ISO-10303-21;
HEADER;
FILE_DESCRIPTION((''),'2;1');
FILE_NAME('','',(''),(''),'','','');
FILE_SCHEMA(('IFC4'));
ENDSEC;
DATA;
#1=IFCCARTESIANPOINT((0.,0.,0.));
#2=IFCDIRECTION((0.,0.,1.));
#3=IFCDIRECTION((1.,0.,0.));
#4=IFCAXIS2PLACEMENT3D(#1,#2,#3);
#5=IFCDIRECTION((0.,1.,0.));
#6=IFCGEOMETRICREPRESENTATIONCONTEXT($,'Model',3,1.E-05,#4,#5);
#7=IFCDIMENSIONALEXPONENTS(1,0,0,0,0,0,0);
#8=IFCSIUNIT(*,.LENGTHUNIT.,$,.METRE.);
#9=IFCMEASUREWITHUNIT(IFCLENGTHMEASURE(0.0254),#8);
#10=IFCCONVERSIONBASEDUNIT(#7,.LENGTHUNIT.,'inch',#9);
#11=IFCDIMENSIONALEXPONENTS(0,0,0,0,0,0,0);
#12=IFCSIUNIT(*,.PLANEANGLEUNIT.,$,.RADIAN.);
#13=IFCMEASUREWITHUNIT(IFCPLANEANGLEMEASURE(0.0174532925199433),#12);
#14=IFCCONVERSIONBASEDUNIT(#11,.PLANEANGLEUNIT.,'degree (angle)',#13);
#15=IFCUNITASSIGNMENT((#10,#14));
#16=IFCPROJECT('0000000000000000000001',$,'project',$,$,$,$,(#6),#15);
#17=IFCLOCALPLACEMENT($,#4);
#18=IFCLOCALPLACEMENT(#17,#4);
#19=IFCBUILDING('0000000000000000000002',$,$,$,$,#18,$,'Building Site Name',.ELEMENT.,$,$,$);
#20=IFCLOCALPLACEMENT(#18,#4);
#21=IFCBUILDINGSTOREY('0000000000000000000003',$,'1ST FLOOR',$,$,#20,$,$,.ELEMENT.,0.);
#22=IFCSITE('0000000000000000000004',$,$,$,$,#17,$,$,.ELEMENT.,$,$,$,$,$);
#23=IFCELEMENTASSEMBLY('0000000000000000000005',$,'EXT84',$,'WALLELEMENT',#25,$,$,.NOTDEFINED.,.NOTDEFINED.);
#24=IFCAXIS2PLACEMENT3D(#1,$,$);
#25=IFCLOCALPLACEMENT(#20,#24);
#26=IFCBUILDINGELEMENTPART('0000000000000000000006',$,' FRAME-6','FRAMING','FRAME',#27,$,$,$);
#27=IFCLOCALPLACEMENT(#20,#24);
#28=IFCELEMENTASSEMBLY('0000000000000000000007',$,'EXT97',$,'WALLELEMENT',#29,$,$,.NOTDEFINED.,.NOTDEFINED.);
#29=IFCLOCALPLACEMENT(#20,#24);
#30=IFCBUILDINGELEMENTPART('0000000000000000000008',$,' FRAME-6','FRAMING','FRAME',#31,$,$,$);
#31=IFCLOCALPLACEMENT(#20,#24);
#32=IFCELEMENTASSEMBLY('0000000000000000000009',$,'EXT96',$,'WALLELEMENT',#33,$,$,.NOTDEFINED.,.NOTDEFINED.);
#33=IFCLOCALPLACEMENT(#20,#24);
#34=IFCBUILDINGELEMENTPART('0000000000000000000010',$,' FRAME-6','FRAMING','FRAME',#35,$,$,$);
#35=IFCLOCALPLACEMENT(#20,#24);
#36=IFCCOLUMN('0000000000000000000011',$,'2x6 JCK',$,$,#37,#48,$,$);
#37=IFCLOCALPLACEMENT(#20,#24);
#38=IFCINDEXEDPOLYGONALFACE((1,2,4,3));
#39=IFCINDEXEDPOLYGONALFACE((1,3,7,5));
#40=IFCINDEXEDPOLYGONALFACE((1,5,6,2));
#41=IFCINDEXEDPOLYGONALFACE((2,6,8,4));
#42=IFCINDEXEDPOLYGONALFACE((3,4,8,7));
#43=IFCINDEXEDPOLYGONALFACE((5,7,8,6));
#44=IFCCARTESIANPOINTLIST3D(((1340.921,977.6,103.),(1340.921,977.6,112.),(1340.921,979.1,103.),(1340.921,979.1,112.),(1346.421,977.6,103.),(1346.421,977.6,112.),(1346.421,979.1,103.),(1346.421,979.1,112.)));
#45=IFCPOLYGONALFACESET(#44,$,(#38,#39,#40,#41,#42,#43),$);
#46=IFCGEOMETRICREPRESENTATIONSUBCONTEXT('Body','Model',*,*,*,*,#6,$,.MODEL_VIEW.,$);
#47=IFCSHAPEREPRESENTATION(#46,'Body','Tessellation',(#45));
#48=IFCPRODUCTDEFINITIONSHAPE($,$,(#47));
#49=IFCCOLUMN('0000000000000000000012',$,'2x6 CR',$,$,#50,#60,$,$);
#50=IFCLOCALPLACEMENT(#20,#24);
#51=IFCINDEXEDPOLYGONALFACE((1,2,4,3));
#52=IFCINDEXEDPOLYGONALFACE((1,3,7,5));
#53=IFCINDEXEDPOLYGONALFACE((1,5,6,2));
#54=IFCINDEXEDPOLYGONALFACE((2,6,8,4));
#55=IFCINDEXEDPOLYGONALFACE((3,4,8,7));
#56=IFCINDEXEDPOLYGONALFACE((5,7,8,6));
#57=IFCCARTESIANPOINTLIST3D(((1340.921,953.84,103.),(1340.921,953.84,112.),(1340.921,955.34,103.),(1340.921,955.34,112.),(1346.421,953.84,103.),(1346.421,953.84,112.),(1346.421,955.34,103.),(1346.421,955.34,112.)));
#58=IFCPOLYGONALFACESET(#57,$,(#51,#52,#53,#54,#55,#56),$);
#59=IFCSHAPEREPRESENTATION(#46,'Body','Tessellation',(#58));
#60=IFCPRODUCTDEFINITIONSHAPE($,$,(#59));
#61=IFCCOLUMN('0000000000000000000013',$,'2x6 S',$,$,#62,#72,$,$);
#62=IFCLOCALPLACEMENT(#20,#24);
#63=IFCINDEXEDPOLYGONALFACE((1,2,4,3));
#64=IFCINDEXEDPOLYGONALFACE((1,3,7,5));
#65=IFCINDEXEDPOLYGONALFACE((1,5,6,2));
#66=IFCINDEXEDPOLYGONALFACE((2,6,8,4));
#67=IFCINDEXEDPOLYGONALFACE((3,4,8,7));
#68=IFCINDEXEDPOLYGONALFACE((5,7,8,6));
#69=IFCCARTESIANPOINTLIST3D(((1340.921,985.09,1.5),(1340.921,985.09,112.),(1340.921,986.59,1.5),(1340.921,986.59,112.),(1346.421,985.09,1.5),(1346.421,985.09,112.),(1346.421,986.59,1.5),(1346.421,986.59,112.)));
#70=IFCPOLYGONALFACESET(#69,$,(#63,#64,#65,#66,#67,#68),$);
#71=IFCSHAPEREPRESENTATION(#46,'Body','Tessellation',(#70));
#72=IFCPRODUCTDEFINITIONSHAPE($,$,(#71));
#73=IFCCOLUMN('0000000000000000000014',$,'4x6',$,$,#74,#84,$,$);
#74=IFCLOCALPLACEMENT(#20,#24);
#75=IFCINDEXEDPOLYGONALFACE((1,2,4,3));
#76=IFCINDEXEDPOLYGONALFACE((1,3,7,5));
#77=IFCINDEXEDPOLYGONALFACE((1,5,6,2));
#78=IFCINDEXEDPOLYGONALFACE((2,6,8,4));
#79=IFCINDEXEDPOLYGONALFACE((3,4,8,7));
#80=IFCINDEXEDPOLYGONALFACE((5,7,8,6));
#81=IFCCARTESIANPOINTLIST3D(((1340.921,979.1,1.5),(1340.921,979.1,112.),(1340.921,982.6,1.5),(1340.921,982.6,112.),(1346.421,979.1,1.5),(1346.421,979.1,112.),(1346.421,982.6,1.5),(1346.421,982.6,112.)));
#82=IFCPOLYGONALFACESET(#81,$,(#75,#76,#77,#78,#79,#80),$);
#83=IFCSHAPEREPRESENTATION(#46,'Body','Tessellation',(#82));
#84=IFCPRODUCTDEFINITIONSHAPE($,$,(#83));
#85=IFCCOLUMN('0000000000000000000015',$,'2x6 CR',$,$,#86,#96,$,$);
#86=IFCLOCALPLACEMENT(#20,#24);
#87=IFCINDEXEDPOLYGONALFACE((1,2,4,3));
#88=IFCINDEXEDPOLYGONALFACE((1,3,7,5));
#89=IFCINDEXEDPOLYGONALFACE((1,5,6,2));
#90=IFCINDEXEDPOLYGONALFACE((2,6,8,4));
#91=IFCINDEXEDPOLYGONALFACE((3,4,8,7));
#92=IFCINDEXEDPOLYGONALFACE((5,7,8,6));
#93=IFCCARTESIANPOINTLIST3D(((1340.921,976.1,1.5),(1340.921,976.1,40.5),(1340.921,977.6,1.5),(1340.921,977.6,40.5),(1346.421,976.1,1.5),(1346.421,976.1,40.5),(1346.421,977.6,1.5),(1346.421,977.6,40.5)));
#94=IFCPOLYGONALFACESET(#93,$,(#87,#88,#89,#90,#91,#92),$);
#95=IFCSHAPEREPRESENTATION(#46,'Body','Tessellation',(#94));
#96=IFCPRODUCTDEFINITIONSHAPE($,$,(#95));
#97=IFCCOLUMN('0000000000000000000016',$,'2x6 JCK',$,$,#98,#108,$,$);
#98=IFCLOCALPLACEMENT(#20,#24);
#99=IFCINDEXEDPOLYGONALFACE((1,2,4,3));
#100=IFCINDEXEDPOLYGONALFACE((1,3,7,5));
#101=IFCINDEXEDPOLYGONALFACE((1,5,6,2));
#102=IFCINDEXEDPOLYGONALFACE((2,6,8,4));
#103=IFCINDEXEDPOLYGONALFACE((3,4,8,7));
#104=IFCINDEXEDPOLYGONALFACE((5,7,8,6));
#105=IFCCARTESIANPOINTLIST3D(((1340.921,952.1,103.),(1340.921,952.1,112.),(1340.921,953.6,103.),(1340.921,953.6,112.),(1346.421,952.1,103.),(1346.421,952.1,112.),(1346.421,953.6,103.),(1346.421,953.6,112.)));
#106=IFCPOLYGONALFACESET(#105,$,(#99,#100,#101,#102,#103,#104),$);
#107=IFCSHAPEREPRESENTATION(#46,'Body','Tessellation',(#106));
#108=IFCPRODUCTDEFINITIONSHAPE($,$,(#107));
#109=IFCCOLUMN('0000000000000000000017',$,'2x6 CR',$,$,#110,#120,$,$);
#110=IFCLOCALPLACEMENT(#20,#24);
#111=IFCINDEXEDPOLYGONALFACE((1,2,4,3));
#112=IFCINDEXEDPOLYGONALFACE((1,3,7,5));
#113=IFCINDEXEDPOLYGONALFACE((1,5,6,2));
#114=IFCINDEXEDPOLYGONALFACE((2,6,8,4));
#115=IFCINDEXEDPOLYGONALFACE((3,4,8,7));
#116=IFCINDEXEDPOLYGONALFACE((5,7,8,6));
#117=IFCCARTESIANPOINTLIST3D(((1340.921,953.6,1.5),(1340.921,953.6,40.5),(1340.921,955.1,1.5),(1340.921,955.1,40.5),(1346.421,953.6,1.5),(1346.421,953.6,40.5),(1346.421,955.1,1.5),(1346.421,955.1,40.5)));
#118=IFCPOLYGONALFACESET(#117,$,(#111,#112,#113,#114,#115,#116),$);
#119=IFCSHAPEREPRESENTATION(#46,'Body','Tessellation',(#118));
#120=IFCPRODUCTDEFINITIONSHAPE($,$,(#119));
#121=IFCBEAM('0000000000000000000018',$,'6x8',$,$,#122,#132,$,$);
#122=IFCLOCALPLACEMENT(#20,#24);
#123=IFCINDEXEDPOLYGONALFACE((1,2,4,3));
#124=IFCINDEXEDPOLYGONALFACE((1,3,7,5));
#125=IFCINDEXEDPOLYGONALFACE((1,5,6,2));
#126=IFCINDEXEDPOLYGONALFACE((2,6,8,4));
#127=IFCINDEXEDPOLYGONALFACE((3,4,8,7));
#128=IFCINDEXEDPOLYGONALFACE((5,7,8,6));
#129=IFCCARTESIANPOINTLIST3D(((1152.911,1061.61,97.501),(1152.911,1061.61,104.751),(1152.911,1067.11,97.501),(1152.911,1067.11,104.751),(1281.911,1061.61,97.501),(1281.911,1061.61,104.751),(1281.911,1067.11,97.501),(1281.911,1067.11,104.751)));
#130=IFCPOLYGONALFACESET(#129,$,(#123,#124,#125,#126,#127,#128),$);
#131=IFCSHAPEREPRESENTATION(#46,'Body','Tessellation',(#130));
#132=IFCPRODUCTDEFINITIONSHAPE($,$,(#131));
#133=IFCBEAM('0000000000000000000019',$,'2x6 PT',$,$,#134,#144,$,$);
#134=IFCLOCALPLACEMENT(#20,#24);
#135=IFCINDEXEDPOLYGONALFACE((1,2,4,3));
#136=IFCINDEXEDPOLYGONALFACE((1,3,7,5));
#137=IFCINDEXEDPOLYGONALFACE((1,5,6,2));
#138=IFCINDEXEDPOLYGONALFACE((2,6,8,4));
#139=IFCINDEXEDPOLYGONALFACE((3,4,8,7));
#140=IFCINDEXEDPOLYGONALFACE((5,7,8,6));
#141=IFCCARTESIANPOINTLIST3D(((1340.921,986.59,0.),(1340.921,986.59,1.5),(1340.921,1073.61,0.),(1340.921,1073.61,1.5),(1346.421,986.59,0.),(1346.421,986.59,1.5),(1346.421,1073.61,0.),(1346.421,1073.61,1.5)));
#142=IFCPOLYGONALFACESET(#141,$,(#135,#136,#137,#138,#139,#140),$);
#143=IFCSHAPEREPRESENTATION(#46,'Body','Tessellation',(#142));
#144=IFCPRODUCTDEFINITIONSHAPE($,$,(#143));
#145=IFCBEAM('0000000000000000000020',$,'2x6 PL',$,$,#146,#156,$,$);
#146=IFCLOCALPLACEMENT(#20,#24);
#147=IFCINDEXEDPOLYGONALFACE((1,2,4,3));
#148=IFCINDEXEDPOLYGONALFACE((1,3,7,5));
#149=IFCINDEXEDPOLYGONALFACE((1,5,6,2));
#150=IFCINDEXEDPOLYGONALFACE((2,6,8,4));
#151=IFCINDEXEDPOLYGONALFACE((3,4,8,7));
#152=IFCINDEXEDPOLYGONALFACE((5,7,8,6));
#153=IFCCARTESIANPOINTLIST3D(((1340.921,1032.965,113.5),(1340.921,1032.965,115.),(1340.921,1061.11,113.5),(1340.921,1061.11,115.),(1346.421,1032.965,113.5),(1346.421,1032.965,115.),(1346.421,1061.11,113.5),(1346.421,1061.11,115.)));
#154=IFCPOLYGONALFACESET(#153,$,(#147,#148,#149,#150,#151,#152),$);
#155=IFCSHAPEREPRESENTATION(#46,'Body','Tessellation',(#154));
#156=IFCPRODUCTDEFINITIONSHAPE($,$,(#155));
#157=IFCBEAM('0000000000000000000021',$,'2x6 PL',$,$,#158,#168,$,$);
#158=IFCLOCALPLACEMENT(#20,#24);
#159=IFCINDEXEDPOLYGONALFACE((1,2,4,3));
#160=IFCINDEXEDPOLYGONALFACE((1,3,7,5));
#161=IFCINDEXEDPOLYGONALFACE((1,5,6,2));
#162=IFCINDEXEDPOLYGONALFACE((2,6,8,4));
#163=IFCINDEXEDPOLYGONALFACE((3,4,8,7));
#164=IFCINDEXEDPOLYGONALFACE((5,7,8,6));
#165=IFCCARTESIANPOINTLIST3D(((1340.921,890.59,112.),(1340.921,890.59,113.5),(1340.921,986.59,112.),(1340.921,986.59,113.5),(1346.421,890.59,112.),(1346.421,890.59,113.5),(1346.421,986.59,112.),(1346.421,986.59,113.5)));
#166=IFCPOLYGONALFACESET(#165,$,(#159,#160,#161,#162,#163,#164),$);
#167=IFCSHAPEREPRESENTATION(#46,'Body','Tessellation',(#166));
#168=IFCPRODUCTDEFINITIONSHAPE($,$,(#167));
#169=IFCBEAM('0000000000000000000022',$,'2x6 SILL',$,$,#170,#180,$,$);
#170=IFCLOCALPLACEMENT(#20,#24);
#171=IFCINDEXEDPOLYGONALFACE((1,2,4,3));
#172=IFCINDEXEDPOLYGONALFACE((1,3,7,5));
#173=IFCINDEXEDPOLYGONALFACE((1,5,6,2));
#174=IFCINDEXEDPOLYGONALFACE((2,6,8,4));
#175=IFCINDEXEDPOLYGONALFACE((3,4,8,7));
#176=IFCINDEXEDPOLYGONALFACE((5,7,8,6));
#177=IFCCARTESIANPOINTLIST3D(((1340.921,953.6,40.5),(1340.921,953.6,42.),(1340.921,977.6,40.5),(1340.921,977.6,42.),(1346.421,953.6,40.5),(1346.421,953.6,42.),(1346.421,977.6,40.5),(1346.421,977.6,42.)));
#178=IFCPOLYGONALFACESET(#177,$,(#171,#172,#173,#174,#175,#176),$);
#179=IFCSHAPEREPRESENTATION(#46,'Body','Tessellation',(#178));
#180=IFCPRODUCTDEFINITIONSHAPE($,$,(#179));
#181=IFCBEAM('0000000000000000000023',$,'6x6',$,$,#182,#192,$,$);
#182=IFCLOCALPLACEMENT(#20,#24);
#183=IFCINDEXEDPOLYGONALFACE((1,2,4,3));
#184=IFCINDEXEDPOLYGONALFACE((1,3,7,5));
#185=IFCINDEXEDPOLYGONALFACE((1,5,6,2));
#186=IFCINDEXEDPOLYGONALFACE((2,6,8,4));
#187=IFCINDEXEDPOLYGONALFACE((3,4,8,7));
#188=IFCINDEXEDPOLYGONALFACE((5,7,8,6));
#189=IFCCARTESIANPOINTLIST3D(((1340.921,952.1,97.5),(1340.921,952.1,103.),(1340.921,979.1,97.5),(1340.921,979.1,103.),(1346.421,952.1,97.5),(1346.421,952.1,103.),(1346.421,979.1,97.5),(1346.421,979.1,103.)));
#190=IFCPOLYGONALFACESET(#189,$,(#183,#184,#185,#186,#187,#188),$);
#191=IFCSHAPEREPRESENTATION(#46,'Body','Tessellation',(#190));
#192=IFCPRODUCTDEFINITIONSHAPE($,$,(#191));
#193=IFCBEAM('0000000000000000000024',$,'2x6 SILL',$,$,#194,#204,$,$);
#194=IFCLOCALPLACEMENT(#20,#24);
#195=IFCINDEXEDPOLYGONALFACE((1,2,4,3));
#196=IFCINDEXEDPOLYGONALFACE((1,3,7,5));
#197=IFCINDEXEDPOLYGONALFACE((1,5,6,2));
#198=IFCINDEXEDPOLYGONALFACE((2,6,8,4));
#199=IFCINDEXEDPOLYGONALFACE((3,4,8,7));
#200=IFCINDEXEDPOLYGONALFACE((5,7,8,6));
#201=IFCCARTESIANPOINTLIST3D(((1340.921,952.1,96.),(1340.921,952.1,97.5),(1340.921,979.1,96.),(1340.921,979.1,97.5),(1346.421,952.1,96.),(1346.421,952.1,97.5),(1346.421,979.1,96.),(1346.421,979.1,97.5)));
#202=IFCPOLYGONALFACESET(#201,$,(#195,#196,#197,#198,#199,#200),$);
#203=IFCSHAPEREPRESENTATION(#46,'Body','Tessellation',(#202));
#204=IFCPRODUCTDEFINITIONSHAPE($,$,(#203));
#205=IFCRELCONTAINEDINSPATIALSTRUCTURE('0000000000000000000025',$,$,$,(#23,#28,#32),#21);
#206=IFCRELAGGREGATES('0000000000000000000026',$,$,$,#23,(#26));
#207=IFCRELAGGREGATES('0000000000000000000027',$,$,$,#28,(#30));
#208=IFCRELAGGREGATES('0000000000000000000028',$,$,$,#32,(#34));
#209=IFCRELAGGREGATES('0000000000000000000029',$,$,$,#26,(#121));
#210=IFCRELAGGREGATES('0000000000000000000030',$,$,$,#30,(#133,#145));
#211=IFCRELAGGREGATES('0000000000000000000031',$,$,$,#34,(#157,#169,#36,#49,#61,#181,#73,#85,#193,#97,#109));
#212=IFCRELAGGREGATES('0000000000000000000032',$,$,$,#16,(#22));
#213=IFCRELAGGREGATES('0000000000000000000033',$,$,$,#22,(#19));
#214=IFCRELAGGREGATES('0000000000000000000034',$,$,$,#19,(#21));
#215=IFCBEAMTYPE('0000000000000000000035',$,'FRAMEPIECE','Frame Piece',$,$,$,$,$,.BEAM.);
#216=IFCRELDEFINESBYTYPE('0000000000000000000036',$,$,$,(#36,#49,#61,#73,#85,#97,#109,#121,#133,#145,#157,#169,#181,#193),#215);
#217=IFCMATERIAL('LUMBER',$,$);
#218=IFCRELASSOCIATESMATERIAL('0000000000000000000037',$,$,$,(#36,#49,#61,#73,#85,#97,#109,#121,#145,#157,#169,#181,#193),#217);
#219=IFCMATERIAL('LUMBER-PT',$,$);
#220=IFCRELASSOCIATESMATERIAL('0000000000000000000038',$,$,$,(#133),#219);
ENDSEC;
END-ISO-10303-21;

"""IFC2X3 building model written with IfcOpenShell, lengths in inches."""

from ifc_helpers import new_model, entity, si_unit, converted_unit, direction, frame, frame_2d, origin_with_axes, place, context, subcontext, project, spatial, polyline, segment, composite_curve, rectangle, outline, extrude, material, type_object, element, aggregate, save


model = new_model("IFC2X3")

# Units and contexts
model_context = context("Model", 3, precision=1e-05, world=origin_with_axes(), true_north=direction((0.0, 1.0, 0.0)))
body_context = subcontext(model_context, "Body", "Model", "MODEL_VIEW")
ifc_project = project(units=[converted_unit("LENGTHUNIT", "inch", entity("IfcLengthMeasure", 0.0254), si_unit("LENGTHUNIT", "METRE"), dimensions=[1, 0, 0, 0, 0, 0, 0]), converted_unit("PLANEANGLEUNIT", "degree (angle)", entity("IfcPlaneAngleMeasure", 0.0174532925199433), si_unit("PLANEANGLEUNIT", "RADIAN"), dimensions=[0, 0, 0, 0, 0, 0, 0])], contexts=[model_context])

# Site, building, storey
site_placement = place(None, origin_with_axes())
site = spatial("IfcSite", under=ifc_project, at=site_placement, CompositionType="ELEMENT")
building_placement = place(site_placement, origin_with_axes())
building = spatial("IfcBuilding", under=site, at=building_placement, LongName="Building Site Name", CompositionType="ELEMENT")
storey_placement = place(building_placement, origin_with_axes())
storey = spatial("IfcBuildingStorey", under=building, at=storey_placement, Name="1ST FLOOR", CompositionType="ELEMENT", Elevation=0.0)

# Element assemblies, building element parts, columns
assembly_1_placement = place(storey_placement, origin_with_axes())
assembly_1 = element("IfcElementAssembly", 1, at=assembly_1_placement, inside=storey, Name="EXT84", ObjectType="WALLELEMENT", AssemblyPlace="NOTDEFINED", PredefinedType="NOTDEFINED")
building_element_part_1 = element("IfcBuildingElementPart", 2, Name=" FRAME-6", Description="FRAMING", ObjectType="FRAME")
aggregate(assembly_1, [building_element_part_1])
ifc_material_1 = material(Name="LUMBER")
beam_type = type_object("IfcBeamType", Name="FRAMEPIECE", Description="Frame Piece", PredefinedType="BEAM")
assembly_2_placement = place(storey_placement, origin_with_axes())
assembly_2 = element("IfcElementAssembly", 3, at=assembly_2_placement, inside=storey, Name="EXT97", ObjectType="WALLELEMENT", AssemblyPlace="NOTDEFINED", PredefinedType="NOTDEFINED")
building_element_part_2 = element("IfcBuildingElementPart", 4, Name=" FRAME-6", Description="FRAMING", ObjectType="FRAME")
aggregate(assembly_2, [building_element_part_2])
assembly_3_placement = place(storey_placement, origin_with_axes())
assembly_3 = element("IfcElementAssembly", 5, at=assembly_3_placement, inside=storey, Name="EXT96", ObjectType="WALLELEMENT", AssemblyPlace="NOTDEFINED", PredefinedType="NOTDEFINED")
building_element_part_3 = element("IfcBuildingElementPart", 6, Name=" FRAME-6", Description="FRAMING", ObjectType="FRAME")
aggregate(assembly_3, [building_element_part_3])
column_1_placement = place(assembly_3_placement, frame((1343.671, 978.35, 103.0), z_axis=(0.0, 0.0, 1.0), x_axis=(0.0, -1.0, 0.0)))
column_1 = element("IfcColumn", 7, at=column_1_placement, type_object=beam_type, material=ifc_material_1, Name="2x6 JCK", context=body_context, shape_type="SweptSolid", body=[
    extrude(rectangle(XDim=1.5, YDim=5.5, at=frame_2d((0.0, 0.0), x_axis=(-1.0, 0.0))), origin_with_axes(), (0.0, 0.0, 1.0), 9.0),
])
column_2_placement = place(assembly_3_placement, frame((1343.671, 954.59, 112.0), z_axis=(0.0, 0.0, -1.0), x_axis=(0.0, 1.0, 0.0)))
column_2 = element("IfcColumn", 8, at=column_2_placement, type_object=beam_type, material=ifc_material_1, Name="2x6 CR", context=body_context, shape_type="SweptSolid", body=[
    extrude(rectangle(XDim=1.5, YDim=5.5, at=frame_2d((0.0, 0.0), x_axis=(-1.0, 0.0))), origin_with_axes(), (0.0, 0.0, 1.0), 9.0),
])
column_3_placement = place(assembly_3_placement, frame((1343.671, 985.84, 1.5), z_axis=(0.0, 0.0, 1.0), x_axis=(0.0, -1.0, 0.0)))
column_3 = element("IfcColumn", 9, at=column_3_placement, type_object=beam_type, material=ifc_material_1, Name="2x6 S", context=body_context, shape_type="SweptSolid", body=[
    extrude(rectangle(XDim=1.5, YDim=5.5, at=frame_2d((0.0, 0.0), x_axis=(-1.0, 0.0))), frame((0.0, 0.0, 0.0), z_axis=(0.0, 0.0, 1.0), x_axis=(1.0, 0.0, 0.0)), (0.0, 0.0, 1.0), 110.5),
])
column_4_placement = place(assembly_3_placement, frame((1343.671, 980.85, 1.5), z_axis=(0.0, 0.0, 1.0), x_axis=(0.0, -1.0, 0.0)))
column_4 = element("IfcColumn", 10, at=column_4_placement, type_object=beam_type, material=ifc_material_1, Name="4x6", context=body_context, shape_type="SweptSolid", body=[
    extrude(outline(composite_curve([segment(polyline([(-1.75, -2.75), (-1.75, 2.75), (1.75, 2.75), (1.75, -2.75), (-1.75, -2.75)]), True, "CONTINUOUS")], self_intersect=False)), origin_with_axes(), (0.0, 0.0, 1.0), 110.5),
])
column_5_placement = place(assembly_3_placement, frame((1343.671, 976.85, 1.5), z_axis=(0.0, 0.0, 1.0), x_axis=(0.0, -1.0, 0.0)))
column_5 = element("IfcColumn", 11, at=column_5_placement, type_object=beam_type, material=ifc_material_1, Name="2x6 CR", context=body_context, shape_type="SweptSolid", body=[
    extrude(rectangle(XDim=1.5, YDim=5.5, at=frame_2d((0.0, 0.0), x_axis=(-1.0, 0.0))), frame((0.0, 0.0, 0.0), z_axis=(0.0, 0.0, 1.0), x_axis=(1.0, 0.0, 0.0)), (0.0, 0.0, 1.0), 39.0),
])
column_6_placement = place(assembly_3_placement, frame((1343.671, 952.85, 112.0), z_axis=(0.0, 0.0, -1.0), x_axis=(0.0, 1.0, 0.0)))
column_6 = element("IfcColumn", 12, at=column_6_placement, type_object=beam_type, material=ifc_material_1, Name="2x6 JCK", context=body_context, shape_type="SweptSolid", body=[
    extrude(rectangle(XDim=1.5, YDim=5.5, at=frame_2d((0.0, 0.0), x_axis=(-1.0, 0.0))), origin_with_axes(), (0.0, 0.0, 1.0), 9.0),
])
column_7_placement = place(assembly_3_placement, frame((1343.671, 954.35, 40.5), z_axis=(0.0, 0.0, -1.0), x_axis=(0.0, 1.0, 0.0)))
column_7 = element("IfcColumn", 13, at=column_7_placement, type_object=beam_type, material=ifc_material_1, Name="2x6 CR", context=body_context, shape_type="SweptSolid", body=[
    extrude(rectangle(XDim=1.5, YDim=5.5, at=frame_2d((0.0, 0.0), x_axis=(-1.0, 0.0))), origin_with_axes(), (0.0, 0.0, 1.0), 39.0),
])

# Beams
beam_1_placement = place(assembly_1_placement, frame((1281.911, 1064.36, 101.126), z_axis=(-1.0, 0.0, 0.0), x_axis=(0.0, -1.0, 0.0)))
beam_1 = element("IfcBeam", 14, at=beam_1_placement, type_object=beam_type, material=ifc_material_1, Name="6x8", context=body_context, shape_type="SweptSolid", body=[
    extrude(rectangle(XDim=5.5, YDim=7.25, at=frame_2d((0.0, 0.0), x_axis=(-1.0, 0.0))), frame((0.0, 0.0, 0.0), z_axis=(0.0, 0.0, 1.0), x_axis=(1.0, 0.0, 0.0)), (0.0, 0.0, 1.0), 129.0),
])
aggregate(building_element_part_1, [beam_1])
ifc_material_2 = material(Name="LUMBER-PT")
beam_2_placement = place(assembly_2_placement, frame((1343.671, 986.59, 0.75), z_axis=(0.0, 1.0, 0.0), x_axis=(0.0, 0.0, 1.0)))
beam_2 = element("IfcBeam", 15, at=beam_2_placement, type_object=beam_type, material=ifc_material_2, Name="2x6 PT", context=body_context, shape_type="SweptSolid", body=[
    extrude(rectangle(XDim=1.5, YDim=5.5, at=frame_2d((0.0, 0.0), x_axis=(-1.0, 0.0))), origin_with_axes(), (0.0, 0.0, 1.0), 87.02),
])
beam_3_placement = place(assembly_2_placement, frame((1343.671, 1061.11, 114.25), z_axis=(0.0, -1.0, 0.0), x_axis=(0.0, 0.0, -1.0)))
beam_3 = element("IfcBeam", 16, at=beam_3_placement, type_object=beam_type, material=ifc_material_1, Name="2x6 PL", context=body_context, shape_type="SweptSolid", body=[
    extrude(rectangle(XDim=1.5, YDim=5.5, at=frame_2d((0.0, 0.0), x_axis=(-1.0, 0.0))), origin_with_axes(), (0.0, 0.0, 1.0), 28.145),
])
aggregate(building_element_part_2, [beam_2, beam_3])
beam_4_placement = place(assembly_3_placement, frame((1343.671, 986.59, 112.75), z_axis=(0.0, -1.0, 0.0), x_axis=(0.0, 0.0, -1.0)))
beam_4 = element("IfcBeam", 17, at=beam_4_placement, type_object=beam_type, material=ifc_material_1, Name="2x6 PL", context=body_context, shape_type="SweptSolid", body=[
    extrude(rectangle(XDim=1.5, YDim=5.5, at=frame_2d((0.0, 0.0), x_axis=(-1.0, 0.0))), origin_with_axes(), (0.0, 0.0, 1.0), 96.0),
])
beam_5_placement = place(assembly_3_placement, frame((1343.671, 977.6, 41.25), z_axis=(0.0, -1.0, 0.0), x_axis=(0.0, 0.0, -1.0)))
beam_5 = element("IfcBeam", 18, at=beam_5_placement, type_object=beam_type, material=ifc_material_1, Name="2x6 SILL", context=body_context, shape_type="SweptSolid", body=[
    extrude(rectangle(XDim=1.5, YDim=5.5, at=frame_2d((0.0, 0.0), x_axis=(-1.0, 0.0))), frame((0.0, 0.0, 0.0), z_axis=(0.0, 0.0, 1.0), x_axis=(1.0, 0.0, 0.0)), (0.0, 0.0, 1.0), 24.0),
])
beam_6_placement = place(assembly_3_placement, frame((1343.671, 952.1, 100.25), z_axis=(0.0, 1.0, 0.0), x_axis=(-1.0, 0.0, 0.0)))
beam_6 = element("IfcBeam", 19, at=beam_6_placement, type_object=beam_type, material=ifc_material_1, Name="6x6", context=body_context, shape_type="SweptSolid", body=[
    extrude(rectangle(XDim=5.5, YDim=5.5, at=frame_2d((0.0, 0.0), x_axis=(-1.0, 0.0))), frame((0.0, 0.0, 0.0), z_axis=(0.0, 0.0, 1.0), x_axis=(1.0, 0.0, 0.0)), (0.0, 0.0, 1.0), 27.0),
])
beam_7_placement = place(assembly_3_placement, frame((1343.671, 952.1, 96.75), z_axis=(0.0, 1.0, 0.0), x_axis=(0.0, 0.0, 1.0)))
beam_7 = element("IfcBeam", 20, at=beam_7_placement, type_object=beam_type, material=ifc_material_1, Name="2x6 SILL", context=body_context, shape_type="SweptSolid", body=[
    extrude(rectangle(XDim=1.5, YDim=5.5, at=frame_2d((0.0, 0.0), x_axis=(-1.0, 0.0))), frame((0.0, 0.0, 0.0), z_axis=(0.0, 0.0, 1.0), x_axis=(1.0, 0.0, 0.0)), (0.0, 0.0, 1.0), 27.0),
])
aggregate(building_element_part_3, [beam_4, beam_5, column_1, column_2, column_3, beam_6, column_4, column_5, beam_7, column_6, column_7])

save(model, "model.ifc")
